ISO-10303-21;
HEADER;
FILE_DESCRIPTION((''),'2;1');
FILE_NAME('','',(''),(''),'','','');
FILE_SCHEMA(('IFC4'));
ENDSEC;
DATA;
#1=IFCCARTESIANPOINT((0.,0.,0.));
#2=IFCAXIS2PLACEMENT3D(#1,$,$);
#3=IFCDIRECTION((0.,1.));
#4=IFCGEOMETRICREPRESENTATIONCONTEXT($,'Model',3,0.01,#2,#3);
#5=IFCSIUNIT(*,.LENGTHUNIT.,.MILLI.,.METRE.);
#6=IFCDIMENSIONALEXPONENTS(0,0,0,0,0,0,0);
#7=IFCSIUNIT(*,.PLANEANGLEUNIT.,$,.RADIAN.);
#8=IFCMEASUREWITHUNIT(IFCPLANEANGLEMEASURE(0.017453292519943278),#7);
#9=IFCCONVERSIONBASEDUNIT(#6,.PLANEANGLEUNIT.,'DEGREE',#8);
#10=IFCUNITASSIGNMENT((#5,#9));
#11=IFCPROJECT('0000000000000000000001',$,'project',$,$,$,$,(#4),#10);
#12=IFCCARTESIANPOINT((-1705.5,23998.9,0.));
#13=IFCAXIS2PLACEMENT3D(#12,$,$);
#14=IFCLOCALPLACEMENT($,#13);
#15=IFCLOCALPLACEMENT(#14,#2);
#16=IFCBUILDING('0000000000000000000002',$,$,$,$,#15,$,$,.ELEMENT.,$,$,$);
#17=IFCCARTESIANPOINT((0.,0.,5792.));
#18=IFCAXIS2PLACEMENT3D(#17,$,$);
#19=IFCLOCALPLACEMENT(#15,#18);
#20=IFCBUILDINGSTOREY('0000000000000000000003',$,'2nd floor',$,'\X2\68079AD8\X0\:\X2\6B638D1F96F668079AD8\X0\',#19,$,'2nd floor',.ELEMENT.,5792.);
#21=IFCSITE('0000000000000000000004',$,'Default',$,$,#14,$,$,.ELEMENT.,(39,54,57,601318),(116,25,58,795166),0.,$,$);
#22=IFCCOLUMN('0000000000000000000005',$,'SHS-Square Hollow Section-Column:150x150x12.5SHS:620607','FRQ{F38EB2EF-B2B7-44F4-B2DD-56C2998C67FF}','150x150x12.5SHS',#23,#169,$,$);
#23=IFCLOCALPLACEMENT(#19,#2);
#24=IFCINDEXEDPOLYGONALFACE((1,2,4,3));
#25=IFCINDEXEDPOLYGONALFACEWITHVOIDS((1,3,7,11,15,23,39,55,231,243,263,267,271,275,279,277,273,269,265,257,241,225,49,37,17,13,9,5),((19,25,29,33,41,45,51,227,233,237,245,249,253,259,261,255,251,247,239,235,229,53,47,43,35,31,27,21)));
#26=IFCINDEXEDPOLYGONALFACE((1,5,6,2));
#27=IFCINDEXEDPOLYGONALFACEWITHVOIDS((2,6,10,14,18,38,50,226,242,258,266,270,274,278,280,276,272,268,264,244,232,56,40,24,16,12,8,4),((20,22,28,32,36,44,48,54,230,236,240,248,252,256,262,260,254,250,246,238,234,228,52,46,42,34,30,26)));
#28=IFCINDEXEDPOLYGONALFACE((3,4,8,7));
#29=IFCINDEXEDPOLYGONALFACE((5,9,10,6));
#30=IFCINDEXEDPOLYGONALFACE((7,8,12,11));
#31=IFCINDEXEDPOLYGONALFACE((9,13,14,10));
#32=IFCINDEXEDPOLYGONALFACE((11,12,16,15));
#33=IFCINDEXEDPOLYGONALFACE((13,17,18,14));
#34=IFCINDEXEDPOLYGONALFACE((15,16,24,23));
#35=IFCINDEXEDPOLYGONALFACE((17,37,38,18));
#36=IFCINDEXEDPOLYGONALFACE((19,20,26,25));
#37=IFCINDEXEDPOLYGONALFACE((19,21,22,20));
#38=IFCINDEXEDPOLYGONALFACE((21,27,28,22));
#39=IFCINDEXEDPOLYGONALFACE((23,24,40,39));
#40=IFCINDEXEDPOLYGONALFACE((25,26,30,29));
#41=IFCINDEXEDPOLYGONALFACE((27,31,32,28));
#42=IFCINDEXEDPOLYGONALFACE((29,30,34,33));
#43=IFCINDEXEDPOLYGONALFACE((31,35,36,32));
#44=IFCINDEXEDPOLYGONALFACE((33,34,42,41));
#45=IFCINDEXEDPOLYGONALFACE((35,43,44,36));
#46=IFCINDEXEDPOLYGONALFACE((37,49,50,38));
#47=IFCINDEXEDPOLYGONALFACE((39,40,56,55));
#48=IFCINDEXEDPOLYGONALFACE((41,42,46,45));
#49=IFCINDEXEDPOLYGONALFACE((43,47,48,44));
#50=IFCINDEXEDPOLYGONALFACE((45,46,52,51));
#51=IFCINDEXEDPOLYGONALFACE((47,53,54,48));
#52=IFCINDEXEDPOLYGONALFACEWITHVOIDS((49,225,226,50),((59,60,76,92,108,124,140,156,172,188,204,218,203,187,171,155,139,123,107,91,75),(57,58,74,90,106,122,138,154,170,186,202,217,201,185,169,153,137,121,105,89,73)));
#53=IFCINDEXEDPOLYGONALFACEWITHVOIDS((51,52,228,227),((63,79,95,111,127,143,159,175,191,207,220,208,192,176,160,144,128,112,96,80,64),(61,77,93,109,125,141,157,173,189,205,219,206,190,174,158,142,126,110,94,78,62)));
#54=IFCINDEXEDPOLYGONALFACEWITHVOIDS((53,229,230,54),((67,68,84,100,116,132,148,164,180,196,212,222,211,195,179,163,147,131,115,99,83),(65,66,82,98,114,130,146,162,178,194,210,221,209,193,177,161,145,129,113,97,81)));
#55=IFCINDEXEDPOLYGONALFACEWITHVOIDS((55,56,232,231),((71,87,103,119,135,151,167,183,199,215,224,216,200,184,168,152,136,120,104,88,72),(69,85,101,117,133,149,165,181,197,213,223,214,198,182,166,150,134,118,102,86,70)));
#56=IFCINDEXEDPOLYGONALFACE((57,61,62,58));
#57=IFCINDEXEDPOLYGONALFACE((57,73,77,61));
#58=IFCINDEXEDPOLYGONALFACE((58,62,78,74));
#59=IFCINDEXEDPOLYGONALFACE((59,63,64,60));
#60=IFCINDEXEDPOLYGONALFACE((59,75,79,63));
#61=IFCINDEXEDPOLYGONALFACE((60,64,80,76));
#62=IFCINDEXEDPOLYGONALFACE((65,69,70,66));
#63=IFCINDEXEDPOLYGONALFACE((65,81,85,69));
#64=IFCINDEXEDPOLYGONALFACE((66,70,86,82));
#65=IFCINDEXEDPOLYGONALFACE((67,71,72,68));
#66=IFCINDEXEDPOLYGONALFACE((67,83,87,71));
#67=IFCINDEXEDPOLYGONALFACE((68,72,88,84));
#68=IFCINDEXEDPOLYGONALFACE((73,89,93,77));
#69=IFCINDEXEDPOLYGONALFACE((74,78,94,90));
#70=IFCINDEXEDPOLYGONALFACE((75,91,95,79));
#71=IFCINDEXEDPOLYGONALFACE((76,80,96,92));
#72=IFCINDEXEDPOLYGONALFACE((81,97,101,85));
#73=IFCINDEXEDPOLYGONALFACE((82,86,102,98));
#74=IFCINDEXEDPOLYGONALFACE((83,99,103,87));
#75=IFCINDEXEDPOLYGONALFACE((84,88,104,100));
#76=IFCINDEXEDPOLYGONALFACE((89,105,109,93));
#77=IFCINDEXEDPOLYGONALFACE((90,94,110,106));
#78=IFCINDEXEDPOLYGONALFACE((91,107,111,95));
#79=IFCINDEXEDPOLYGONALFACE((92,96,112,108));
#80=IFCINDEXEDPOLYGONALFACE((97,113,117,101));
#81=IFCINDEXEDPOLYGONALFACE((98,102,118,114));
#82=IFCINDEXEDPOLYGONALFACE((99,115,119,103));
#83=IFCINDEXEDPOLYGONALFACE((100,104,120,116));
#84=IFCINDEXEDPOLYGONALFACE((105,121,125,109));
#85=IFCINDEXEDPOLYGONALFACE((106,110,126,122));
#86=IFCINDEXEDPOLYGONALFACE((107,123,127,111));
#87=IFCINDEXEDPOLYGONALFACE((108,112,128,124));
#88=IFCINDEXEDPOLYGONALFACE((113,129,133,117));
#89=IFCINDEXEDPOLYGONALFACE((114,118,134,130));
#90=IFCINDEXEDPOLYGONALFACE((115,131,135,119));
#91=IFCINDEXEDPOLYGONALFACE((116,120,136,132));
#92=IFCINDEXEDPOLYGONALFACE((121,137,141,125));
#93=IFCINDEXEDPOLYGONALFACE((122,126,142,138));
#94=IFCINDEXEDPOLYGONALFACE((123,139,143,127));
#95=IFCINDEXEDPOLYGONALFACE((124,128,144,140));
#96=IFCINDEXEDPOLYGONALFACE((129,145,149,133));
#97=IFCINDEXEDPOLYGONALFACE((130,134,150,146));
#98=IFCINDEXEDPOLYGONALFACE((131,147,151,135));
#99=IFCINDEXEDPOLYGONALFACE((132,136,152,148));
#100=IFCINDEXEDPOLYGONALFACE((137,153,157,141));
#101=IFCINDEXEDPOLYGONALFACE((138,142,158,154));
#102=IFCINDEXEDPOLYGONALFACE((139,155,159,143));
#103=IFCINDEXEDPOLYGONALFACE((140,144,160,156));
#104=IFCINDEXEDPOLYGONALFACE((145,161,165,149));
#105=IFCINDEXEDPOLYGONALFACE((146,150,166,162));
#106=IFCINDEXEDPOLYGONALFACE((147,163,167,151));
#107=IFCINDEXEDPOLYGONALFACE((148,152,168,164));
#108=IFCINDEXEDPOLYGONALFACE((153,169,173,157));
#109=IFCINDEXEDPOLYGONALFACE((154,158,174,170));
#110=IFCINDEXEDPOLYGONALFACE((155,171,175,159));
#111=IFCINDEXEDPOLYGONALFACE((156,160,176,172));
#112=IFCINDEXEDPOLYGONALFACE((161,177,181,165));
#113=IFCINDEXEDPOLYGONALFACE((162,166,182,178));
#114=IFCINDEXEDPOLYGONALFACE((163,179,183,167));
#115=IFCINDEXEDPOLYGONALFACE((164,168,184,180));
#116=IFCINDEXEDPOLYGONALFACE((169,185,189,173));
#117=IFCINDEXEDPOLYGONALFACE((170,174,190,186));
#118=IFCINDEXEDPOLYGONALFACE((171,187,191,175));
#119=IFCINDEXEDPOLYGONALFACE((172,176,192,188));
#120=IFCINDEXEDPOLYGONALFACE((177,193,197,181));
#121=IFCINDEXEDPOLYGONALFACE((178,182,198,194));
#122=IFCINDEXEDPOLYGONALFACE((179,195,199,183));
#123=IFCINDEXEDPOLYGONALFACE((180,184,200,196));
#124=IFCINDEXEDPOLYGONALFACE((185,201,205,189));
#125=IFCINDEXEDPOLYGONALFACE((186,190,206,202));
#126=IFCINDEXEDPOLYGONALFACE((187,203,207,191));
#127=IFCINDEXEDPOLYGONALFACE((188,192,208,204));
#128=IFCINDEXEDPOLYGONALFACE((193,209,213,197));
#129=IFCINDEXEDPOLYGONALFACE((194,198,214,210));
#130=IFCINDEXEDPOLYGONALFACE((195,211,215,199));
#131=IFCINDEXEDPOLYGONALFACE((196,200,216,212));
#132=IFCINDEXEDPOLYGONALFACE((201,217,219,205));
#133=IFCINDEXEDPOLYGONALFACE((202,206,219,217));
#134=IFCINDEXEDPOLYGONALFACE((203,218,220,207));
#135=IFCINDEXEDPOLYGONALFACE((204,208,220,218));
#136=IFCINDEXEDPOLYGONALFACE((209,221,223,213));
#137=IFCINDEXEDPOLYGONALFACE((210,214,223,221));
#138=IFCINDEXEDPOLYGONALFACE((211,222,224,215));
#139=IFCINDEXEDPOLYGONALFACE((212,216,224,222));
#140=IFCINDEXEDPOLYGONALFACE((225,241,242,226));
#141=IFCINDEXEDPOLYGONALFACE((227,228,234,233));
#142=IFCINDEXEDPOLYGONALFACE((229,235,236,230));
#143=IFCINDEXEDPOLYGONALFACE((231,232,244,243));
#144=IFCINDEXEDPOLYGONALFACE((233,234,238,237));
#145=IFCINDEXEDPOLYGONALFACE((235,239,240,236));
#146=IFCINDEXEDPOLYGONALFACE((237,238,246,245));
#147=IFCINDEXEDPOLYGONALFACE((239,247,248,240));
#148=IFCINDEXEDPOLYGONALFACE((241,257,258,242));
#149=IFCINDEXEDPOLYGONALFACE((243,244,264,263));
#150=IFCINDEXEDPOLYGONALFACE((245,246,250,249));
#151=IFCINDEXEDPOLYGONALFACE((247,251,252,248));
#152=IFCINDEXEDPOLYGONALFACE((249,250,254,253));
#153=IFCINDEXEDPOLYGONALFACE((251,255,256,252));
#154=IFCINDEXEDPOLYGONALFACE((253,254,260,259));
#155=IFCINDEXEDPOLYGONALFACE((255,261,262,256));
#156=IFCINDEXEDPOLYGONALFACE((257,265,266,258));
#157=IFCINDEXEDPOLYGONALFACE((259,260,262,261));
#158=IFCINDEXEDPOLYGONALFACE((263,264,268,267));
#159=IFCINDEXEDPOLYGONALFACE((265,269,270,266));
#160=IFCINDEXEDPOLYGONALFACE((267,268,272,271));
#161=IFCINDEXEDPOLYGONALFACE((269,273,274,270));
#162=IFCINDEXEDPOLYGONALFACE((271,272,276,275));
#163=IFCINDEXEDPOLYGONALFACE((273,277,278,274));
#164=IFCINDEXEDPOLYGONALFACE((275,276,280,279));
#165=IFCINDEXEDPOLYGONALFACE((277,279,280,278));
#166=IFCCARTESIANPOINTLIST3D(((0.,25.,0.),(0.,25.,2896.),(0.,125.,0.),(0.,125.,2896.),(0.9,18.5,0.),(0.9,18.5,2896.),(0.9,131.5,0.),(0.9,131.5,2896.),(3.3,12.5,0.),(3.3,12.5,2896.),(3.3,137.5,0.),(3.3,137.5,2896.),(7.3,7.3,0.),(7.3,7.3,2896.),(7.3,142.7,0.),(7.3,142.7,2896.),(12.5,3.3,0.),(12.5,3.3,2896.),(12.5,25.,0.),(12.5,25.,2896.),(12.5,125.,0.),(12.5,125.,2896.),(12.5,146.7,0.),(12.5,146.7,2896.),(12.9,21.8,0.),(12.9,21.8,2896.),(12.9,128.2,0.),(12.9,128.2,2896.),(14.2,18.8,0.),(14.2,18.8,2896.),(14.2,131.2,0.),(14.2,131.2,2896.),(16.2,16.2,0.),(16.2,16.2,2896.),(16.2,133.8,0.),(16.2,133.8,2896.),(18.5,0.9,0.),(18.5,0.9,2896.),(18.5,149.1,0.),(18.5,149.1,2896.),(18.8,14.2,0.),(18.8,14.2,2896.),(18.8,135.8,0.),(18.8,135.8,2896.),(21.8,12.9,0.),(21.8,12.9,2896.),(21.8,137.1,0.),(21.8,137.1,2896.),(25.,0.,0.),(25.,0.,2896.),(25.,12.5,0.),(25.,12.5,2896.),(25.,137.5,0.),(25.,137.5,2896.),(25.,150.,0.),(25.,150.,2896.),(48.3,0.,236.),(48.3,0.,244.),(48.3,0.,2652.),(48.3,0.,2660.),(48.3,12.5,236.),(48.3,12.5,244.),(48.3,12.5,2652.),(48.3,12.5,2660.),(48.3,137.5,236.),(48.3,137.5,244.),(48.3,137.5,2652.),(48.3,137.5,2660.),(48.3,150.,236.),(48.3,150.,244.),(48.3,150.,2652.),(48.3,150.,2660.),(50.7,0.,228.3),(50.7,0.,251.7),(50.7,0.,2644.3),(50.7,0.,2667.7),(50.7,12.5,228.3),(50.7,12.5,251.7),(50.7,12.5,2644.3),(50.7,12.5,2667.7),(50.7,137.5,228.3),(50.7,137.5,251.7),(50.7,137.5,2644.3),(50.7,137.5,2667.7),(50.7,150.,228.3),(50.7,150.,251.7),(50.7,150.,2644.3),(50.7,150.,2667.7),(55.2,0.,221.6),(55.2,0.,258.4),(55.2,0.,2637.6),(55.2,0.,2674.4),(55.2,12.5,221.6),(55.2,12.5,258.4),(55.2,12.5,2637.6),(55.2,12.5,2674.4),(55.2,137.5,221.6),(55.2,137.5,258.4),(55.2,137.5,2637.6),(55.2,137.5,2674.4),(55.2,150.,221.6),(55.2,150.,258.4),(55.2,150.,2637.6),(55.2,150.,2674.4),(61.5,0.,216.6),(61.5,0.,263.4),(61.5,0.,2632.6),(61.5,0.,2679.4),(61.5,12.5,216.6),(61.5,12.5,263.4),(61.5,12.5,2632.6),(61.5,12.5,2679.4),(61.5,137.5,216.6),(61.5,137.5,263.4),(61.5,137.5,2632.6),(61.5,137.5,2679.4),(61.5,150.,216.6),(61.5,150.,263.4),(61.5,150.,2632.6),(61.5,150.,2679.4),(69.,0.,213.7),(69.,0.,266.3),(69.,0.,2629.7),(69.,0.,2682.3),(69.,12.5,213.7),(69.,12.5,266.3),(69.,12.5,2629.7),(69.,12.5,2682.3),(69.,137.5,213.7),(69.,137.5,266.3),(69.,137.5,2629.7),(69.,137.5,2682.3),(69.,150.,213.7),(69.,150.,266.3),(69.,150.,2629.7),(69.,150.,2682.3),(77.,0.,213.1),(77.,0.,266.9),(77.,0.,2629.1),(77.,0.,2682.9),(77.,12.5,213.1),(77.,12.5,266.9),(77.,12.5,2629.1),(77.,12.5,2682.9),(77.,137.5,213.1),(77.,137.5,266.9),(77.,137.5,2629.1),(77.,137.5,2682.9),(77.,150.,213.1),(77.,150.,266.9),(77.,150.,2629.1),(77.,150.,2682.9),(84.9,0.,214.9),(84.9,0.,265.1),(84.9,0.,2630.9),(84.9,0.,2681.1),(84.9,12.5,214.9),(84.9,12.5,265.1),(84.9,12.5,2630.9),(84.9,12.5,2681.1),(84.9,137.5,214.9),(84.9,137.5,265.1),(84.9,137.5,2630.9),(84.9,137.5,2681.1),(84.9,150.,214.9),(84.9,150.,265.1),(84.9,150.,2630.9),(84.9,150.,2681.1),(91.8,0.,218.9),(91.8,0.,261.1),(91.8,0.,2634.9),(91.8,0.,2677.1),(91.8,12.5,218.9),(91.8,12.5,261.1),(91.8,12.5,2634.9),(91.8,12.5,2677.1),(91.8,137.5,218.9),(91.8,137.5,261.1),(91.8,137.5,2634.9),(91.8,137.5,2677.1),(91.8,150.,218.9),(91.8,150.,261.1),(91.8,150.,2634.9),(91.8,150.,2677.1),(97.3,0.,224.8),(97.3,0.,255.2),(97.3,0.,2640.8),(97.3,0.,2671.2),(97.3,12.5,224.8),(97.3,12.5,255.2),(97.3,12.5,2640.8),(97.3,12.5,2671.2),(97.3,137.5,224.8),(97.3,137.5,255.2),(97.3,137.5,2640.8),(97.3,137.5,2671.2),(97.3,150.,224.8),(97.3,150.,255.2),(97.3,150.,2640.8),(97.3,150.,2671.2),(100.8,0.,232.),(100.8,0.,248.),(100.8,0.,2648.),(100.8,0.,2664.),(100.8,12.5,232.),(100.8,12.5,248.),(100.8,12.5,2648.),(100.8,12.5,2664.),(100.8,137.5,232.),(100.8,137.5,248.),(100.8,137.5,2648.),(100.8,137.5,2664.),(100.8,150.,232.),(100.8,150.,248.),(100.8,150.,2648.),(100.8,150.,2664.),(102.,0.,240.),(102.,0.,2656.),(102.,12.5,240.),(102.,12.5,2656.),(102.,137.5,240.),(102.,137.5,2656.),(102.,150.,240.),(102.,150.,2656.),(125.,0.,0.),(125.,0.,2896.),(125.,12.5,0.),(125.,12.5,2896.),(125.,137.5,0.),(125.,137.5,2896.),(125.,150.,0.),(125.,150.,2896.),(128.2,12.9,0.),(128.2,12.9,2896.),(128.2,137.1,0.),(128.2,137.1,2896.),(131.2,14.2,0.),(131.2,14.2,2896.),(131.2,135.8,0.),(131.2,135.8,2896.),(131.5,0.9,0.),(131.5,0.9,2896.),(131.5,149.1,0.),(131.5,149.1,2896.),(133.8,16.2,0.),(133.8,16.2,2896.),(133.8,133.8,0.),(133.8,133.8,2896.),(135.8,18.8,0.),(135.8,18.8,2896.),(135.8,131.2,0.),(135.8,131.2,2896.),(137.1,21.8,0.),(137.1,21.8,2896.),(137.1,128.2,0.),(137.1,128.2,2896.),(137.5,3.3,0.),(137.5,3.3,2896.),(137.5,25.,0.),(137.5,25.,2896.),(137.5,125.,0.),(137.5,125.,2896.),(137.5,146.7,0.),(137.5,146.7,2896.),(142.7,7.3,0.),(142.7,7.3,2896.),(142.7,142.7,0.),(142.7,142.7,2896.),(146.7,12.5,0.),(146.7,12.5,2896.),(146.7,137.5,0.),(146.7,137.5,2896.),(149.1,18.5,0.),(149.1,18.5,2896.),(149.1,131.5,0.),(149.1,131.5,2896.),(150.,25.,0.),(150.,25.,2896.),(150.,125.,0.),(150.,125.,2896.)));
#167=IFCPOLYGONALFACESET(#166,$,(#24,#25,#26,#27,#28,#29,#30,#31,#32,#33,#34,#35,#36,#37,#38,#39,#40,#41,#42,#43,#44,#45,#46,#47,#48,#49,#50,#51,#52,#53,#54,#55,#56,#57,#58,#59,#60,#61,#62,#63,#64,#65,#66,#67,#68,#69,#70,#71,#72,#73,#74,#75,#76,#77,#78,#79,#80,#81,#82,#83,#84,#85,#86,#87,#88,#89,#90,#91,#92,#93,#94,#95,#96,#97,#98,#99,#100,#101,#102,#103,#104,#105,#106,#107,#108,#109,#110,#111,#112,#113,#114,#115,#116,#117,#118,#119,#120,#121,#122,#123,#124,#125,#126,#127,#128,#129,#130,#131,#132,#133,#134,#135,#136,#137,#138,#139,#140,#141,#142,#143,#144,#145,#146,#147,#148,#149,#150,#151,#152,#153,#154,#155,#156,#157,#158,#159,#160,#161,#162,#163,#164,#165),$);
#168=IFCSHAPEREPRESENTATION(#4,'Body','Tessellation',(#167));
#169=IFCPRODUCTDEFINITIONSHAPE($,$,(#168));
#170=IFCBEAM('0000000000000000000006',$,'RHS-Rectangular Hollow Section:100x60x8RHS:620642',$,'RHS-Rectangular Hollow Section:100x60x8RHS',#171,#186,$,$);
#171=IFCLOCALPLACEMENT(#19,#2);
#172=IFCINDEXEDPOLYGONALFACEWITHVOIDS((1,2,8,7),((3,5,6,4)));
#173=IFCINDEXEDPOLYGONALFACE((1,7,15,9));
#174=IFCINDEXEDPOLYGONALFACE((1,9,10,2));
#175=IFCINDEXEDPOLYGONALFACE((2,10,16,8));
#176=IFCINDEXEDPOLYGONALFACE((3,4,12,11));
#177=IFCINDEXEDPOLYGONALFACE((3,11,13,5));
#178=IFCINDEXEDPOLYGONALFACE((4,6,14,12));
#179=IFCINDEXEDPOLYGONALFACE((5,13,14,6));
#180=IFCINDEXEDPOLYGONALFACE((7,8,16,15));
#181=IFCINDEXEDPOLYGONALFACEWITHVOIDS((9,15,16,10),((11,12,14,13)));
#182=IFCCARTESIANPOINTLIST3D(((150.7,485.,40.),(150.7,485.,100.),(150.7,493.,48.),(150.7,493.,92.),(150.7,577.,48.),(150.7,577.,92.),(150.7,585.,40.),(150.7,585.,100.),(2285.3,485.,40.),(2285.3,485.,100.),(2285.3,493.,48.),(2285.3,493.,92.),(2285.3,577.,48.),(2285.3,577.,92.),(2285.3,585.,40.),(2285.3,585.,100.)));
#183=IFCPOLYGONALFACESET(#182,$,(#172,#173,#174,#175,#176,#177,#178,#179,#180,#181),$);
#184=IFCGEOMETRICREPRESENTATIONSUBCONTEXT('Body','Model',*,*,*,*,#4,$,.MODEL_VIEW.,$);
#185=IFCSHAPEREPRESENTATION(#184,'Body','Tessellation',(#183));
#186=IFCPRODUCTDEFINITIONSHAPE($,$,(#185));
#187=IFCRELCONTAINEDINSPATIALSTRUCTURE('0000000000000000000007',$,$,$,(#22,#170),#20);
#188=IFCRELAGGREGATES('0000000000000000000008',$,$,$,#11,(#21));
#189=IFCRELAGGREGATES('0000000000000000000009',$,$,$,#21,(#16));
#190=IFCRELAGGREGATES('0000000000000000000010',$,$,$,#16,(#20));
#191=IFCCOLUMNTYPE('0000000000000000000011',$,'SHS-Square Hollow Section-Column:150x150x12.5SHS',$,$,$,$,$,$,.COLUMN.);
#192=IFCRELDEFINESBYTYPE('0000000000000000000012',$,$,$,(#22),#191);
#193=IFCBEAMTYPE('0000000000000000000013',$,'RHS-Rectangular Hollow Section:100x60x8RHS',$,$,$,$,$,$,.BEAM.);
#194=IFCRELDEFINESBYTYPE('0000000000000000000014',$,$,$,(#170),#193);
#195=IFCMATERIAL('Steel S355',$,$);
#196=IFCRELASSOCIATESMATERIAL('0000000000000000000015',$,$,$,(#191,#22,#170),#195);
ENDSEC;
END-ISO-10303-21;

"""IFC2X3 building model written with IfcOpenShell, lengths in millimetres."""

from ifc_helpers import new_model, entity, si_unit, converted_unit, direction, frame, frame_2d, origin, origin_2d, place, context, subcontext, project, spatial, circle_curve, rectangle, hollow_rectangle, outline, extrude, boolean, material, type_object, element, save


model = new_model("IFC2X3")

# Units and contexts
model_context = context("Model", 3, precision=0.01, world=origin(), true_north=direction((0.0, 1.0)))
body_context = subcontext(model_context, "Body", "Model", "MODEL_VIEW")
ifc_project = project(units=[si_unit("LENGTHUNIT", "METRE", prefix="MILLI"), converted_unit("PLANEANGLEUNIT", "DEGREE", entity("IfcPlaneAngleMeasure", 0.017453292519943278), si_unit("PLANEANGLEUNIT", "RADIAN"), dimensions=[0, 0, 0, 0, 0, 0, 0])], contexts=[model_context])

# Site, building, storey
site_placement = place(None, frame((-1705.5, 23998.9, 0.0)))
site = spatial("IfcSite", under=ifc_project, at=site_placement, Name="Default", CompositionType="ELEMENT", RefLatitude=(39, 54, 57, 601318), RefLongitude=(116, 25, 58, 795166), RefElevation=0.0)
building_placement = place(site_placement, origin())
building = spatial("IfcBuilding", under=site, at=building_placement, CompositionType="ELEMENT")
storey_placement = place(building_placement, frame((0.0, 0.0, 5792.0)))
storey = spatial("IfcBuildingStorey", under=building, at=storey_placement, Name="2nd floor", ObjectType="标高:正负零标高", LongName="2nd floor", CompositionType="ELEMENT", Elevation=5792.0)

# Shared definitions
ifc_material_1 = material(Name="Steel S355")

# Column, openings
column_type_1 = type_object("IfcColumnType", Name="SHS-Square Hollow Section-Column:150x150x12.5SHS", PredefinedType="COLUMN", material=ifc_material_1)
column_1_placement = place(storey_placement, frame((75.0, 75.0, 2896.0), z_axis=(0.0, 0.0, 1.0), x_axis=(0.0, -1.0, 0.0)))
column_1 = element("IfcColumn", 1, at=column_1_placement, inside=storey, type_object=column_type_1, material=ifc_material_1, Name="SHS-Square Hollow Section-Column:150x150x12.5SHS:620607", Description="FRQ{F38EB2EF-B2B7-44F4-B2DD-56C2998C67FF}", ObjectType="150x150x12.5SHS", context=model_context, shape_type="SweptSolid", body=[
    extrude(hollow_rectangle(XDim=150.0, YDim=150.0, WallThickness=12.5, InnerFilletRadius=12.5, OuterFilletRadius=25.0, at=origin_2d()), origin(), (0.0, 0.0, -1.0), 2896.0),
])
opening_1_placement = place(column_1_placement, frame((-175.1, 0.0, -2896.0), z_axis=(1.0, 0.0, 0.0), x_axis=(0.0, 1.0, 0.0)))
element("IfcOpeningElement", 2, at=opening_1_placement, cuts=column_1, ObjectType="Opening", context=model_context, shape_type="SweptSolid", body=[
    extrude(outline(circle_curve(frame_2d((0.0, 240.0), x_axis=(1.0, 0.0)), 27.0)), origin(), (0.0, 0.0, 1.0), 350.2),
])
opening_2_placement = place(column_1_placement, frame((-175.1, 0.0, 0.0), z_axis=(1.0, 0.0, 0.0), x_axis=(0.0, 1.0, 0.0)))
element("IfcOpeningElement", 3, at=opening_2_placement, cuts=column_1, ObjectType="Opening", context=model_context, shape_type="SweptSolid", body=[
    extrude(outline(circle_curve(frame_2d((0.0, -240.0), x_axis=(1.0, 0.0)), 27.0)), origin(), (0.0, 0.0, 1.0), 350.2),
])

# Beam
beam_type_1 = type_object("IfcBeamType", Name="RHS-Rectangular Hollow Section:100x60x8RHS", PredefinedType="BEAM")
beam_1_placement = place(storey_placement, frame((150.7, 585.0, 70.0)))
element("IfcBeam", 4, at=beam_1_placement, inside=storey, type_object=beam_type_1, material=ifc_material_1, Name="RHS-Rectangular Hollow Section:100x60x8RHS:620642", ObjectType="RHS-Rectangular Hollow Section:100x60x8RHS", context=body_context, shape_type="SweptSolid", body=[
    boolean("DIFFERENCE", extrude(rectangle(XDim=60.0, YDim=100.0, at=frame_2d((0.0, 0.0), x_axis=(1.0, 0.0))), frame((0.0, -50.0, 0.0), z_axis=(1.0, 0.0, 0.0), x_axis=(0.0, 0.0, -1.0)), (0.0, 0.0, 1.0), 2134.6), extrude(rectangle(XDim=44.0, YDim=84.0, at=frame_2d((0.0, 0.0), x_axis=(0.0, 1.0))), frame((2134.6, -50.0, 0.0), z_axis=(-1.0, 0.0, 0.0), x_axis=(0.0, 1.0, 0.0)), (0.0, 0.0, 1.0), 2134.6)),
])

save(model, "model.ifc")
